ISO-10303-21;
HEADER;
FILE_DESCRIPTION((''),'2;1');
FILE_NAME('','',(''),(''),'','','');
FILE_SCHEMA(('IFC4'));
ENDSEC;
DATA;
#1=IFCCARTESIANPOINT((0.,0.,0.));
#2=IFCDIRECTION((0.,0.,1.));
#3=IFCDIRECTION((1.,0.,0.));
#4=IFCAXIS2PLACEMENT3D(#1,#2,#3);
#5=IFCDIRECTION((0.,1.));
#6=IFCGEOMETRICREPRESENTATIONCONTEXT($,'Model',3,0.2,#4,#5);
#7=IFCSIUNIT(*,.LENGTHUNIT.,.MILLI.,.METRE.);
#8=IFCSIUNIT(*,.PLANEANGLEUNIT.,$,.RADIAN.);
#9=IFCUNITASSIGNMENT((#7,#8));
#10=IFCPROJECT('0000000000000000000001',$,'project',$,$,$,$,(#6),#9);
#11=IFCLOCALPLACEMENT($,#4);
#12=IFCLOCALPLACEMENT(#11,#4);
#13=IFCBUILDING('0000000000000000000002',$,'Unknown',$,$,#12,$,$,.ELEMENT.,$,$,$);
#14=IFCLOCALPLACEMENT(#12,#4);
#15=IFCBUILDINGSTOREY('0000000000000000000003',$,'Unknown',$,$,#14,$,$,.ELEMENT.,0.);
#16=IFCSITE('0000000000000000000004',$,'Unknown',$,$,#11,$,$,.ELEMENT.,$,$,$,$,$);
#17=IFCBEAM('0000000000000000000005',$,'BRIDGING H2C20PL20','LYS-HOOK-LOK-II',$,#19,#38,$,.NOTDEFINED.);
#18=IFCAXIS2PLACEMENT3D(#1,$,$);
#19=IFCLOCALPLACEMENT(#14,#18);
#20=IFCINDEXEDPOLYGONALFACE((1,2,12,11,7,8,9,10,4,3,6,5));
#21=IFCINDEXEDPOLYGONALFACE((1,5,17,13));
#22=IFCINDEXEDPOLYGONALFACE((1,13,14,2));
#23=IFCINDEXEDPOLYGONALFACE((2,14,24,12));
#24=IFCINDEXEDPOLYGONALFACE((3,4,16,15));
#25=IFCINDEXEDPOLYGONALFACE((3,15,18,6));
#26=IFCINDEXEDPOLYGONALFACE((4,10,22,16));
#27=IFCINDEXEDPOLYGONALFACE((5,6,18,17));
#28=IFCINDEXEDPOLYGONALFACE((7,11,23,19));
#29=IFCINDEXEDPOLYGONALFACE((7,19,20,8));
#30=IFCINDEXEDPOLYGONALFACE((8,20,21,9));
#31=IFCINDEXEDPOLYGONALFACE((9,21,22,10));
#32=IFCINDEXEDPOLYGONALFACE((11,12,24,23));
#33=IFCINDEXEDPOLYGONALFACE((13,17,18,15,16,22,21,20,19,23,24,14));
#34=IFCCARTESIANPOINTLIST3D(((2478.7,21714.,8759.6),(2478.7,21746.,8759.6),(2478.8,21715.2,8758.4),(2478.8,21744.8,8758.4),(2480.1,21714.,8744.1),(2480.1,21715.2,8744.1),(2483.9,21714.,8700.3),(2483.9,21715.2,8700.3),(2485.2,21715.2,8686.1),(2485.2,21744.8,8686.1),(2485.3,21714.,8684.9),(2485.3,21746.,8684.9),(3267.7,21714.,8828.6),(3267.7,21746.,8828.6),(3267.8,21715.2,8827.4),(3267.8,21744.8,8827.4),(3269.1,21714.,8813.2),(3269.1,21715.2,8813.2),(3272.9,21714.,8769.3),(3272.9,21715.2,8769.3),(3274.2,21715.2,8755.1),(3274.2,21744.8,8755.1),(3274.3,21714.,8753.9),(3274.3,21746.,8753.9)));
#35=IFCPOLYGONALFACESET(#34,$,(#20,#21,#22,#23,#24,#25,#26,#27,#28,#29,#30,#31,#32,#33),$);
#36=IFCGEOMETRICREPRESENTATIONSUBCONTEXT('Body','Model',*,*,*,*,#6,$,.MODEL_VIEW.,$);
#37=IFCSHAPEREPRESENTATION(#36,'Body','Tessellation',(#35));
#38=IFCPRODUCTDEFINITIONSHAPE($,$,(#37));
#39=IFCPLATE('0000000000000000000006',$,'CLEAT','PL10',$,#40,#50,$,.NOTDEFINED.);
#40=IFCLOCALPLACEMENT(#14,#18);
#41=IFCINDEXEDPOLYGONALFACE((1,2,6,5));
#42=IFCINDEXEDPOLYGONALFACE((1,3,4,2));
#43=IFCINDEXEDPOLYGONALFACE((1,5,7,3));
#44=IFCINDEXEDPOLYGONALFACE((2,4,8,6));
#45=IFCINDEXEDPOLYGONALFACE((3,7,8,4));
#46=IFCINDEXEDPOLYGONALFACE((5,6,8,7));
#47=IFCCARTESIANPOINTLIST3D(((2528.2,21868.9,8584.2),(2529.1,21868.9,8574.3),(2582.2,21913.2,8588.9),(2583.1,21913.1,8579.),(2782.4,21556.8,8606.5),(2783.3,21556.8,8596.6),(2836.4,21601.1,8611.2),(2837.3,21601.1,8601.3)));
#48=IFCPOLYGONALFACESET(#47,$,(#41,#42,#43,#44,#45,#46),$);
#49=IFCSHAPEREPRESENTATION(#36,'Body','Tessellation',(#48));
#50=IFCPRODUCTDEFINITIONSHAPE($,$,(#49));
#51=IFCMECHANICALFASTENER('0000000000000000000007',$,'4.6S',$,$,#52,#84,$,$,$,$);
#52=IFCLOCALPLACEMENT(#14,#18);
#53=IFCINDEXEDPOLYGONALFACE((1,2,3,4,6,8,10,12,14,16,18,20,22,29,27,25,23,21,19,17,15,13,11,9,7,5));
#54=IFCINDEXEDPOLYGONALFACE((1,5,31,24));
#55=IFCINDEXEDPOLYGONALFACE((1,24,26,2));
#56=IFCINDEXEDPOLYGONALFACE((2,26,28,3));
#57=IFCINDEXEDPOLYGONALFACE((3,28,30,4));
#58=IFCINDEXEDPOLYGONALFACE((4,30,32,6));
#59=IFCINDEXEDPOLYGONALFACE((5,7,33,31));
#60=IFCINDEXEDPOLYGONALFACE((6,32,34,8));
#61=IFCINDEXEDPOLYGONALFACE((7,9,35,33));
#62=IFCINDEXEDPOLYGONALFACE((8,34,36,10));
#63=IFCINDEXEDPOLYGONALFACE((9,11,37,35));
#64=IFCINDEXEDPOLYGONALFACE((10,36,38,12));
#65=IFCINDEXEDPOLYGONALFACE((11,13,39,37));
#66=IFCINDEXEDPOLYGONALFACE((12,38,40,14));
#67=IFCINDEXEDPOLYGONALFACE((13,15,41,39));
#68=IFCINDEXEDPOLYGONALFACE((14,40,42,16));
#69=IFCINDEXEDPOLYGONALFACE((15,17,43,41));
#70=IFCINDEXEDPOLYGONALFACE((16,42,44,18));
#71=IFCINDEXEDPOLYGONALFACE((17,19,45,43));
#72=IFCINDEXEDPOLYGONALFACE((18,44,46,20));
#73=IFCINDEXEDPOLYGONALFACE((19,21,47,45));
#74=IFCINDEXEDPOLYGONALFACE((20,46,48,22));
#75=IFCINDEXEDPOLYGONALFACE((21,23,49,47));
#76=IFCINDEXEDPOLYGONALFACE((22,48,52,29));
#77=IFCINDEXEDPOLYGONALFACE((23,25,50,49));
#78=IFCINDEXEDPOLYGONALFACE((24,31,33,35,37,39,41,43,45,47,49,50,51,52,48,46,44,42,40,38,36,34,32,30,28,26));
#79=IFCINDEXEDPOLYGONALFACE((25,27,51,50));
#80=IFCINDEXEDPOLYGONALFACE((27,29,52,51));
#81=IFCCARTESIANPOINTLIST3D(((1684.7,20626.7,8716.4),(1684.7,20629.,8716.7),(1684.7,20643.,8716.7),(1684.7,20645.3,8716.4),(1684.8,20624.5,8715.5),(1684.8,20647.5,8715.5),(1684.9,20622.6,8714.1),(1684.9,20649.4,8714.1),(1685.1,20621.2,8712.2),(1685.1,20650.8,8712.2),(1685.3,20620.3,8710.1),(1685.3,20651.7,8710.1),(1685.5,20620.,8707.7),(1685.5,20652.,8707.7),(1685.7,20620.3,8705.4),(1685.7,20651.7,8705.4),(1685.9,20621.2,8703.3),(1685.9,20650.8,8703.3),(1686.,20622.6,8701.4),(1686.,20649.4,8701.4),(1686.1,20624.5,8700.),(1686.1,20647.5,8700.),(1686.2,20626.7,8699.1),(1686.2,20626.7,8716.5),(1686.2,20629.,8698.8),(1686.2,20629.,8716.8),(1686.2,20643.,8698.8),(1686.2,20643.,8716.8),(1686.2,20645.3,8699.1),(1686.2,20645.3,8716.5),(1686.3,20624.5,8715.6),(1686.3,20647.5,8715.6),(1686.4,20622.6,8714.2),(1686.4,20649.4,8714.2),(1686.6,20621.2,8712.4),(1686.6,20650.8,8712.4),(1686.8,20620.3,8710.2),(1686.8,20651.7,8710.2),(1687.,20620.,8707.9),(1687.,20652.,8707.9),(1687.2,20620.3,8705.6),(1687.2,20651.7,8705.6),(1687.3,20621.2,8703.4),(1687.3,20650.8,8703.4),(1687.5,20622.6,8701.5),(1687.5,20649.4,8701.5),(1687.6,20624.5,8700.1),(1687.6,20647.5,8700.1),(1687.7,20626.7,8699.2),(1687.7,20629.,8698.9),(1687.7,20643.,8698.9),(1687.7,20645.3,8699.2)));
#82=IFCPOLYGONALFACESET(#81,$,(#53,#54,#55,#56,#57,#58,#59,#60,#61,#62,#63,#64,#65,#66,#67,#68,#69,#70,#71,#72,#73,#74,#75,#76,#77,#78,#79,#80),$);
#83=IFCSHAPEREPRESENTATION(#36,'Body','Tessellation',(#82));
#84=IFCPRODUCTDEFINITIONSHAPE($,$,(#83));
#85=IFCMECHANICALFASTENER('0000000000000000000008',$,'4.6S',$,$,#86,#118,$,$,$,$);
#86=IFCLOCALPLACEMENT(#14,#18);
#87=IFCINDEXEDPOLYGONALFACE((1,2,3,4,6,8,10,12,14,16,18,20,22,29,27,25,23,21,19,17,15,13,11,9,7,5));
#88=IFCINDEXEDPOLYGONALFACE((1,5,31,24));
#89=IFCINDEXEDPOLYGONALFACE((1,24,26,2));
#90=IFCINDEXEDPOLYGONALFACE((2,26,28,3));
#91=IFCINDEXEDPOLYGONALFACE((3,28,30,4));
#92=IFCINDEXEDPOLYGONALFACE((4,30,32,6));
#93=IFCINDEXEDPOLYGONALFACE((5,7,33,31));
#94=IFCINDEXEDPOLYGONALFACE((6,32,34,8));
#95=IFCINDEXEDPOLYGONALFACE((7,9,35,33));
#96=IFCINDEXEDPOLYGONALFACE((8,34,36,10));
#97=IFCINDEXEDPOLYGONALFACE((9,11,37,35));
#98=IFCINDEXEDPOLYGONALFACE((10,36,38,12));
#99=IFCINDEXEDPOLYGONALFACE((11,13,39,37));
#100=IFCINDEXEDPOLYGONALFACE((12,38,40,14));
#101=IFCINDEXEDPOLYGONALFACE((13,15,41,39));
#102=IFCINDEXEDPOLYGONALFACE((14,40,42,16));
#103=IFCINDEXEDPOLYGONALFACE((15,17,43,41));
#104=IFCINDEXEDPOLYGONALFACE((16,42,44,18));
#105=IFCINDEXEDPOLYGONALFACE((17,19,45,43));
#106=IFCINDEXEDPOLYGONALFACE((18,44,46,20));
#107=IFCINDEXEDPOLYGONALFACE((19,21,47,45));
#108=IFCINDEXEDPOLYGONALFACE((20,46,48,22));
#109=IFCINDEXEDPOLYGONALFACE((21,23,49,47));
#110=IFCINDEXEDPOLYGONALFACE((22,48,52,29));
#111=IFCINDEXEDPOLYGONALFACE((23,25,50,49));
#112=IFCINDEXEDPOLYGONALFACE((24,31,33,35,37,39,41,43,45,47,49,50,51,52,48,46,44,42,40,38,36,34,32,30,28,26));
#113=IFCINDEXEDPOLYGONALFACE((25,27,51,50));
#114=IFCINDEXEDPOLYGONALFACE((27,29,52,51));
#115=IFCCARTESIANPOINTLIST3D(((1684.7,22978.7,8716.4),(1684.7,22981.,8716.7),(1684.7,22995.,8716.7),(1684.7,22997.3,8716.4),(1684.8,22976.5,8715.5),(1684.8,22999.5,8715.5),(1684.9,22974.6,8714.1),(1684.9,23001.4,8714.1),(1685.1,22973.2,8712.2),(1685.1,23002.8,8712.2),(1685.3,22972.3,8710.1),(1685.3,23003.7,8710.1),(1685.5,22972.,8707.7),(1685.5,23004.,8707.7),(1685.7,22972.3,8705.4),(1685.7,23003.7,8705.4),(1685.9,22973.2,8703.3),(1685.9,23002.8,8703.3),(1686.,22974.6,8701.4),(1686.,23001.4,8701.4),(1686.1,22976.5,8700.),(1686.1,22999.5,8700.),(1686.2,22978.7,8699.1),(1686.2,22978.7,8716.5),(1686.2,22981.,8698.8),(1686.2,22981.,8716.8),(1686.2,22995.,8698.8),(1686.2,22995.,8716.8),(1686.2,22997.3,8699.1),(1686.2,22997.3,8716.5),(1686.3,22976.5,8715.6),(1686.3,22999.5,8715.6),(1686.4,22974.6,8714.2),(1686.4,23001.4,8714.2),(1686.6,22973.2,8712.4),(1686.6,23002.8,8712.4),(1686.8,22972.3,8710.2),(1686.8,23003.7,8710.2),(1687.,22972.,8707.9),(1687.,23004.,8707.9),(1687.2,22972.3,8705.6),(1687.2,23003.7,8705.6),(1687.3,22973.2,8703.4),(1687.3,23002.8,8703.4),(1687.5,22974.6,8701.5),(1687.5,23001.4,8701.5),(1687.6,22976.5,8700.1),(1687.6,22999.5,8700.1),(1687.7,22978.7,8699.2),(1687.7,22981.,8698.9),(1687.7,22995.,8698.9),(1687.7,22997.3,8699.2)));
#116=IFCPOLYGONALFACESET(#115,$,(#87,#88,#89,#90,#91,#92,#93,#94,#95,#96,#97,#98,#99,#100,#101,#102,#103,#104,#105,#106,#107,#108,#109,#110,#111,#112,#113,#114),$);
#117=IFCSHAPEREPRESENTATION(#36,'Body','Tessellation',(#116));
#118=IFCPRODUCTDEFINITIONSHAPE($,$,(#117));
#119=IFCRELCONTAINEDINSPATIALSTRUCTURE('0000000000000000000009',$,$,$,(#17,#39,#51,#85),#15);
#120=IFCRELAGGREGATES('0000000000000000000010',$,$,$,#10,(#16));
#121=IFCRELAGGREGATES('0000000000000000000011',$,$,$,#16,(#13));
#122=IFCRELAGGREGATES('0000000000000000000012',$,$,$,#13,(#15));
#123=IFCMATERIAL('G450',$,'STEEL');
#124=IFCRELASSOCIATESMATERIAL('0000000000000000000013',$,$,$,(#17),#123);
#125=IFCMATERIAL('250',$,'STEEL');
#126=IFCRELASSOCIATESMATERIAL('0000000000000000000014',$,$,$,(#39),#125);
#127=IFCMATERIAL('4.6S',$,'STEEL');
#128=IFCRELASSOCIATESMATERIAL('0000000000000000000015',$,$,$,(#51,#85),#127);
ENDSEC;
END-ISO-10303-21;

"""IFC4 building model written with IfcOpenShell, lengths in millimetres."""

from ifc_helpers import new_model, si_unit, direction, frame, origin_with_axes, place, context, subcontext, project, spatial, line, arc, indexed_curve, outline, extrude, source, transform, mapped, material, element, save


model = new_model("IFC4")

# Units and contexts
model_context = context("Model", 3, precision=0.2, world=origin_with_axes(), true_north=direction((0.0, 1.0)))
body_context = subcontext(model_context, "Body", "Model", "MODEL_VIEW")
ifc_project = project(units=[si_unit("LENGTHUNIT", "METRE", prefix="MILLI"), si_unit("PLANEANGLEUNIT", "RADIAN")], contexts=[model_context])

# Site, building, storey
site_placement = place(None, origin_with_axes())
site = spatial("IfcSite", under=ifc_project, at=site_placement, Name="Unknown", CompositionType="ELEMENT")
building_placement = place(site_placement, origin_with_axes())
building = spatial("IfcBuilding", under=site, at=building_placement, Name="Unknown", CompositionType="ELEMENT")
storey_placement = place(building_placement, origin_with_axes())
storey = spatial("IfcBuildingStorey", under=building, at=storey_placement, Name="Unknown", CompositionType="ELEMENT", Elevation=0.0)

# Beam
ifc_material_1 = material(Name="250", Category="STEEL")
ifc_material_2 = material(Name="G450", Category="STEEL")
beam_1_placement = place(storey_placement, frame((2482.0, 21730.0, 8722.2), z_axis=(0.0, -1.0, 0.0), x_axis=(0.996195, 0.0, 0.087156)))
element("IfcBeam", 1, at=beam_1_placement, inside=storey, material=ifc_material_2, Name="BRIDGING H2C20PL20", Description="LYS-HOOK-LOK-II", PredefinedType="NOTDEFINED", context=body_context, shape_type="SolidModel", body=[
    extrude(outline(indexed_curve([(16.0, -37.5), (16.0, -22.0), (14.8, -22.0), (14.8, -36.3), (-14.8, -36.3), (-14.8, 36.3), (14.8, 36.3), (14.8, 22.0), (16.0, 22.0), (16.0, 37.5), (-16.0, 37.5), (-16.0, -37.5)], segments=[line(1, 2, 3, 4, 5, 6, 7, 8, 9, 10, 11, 12, 1)])), frame((0.0, 0.0, 0.0), z_axis=(-1.0, 0.0, 0.0), x_axis=(0.0, 0.0, 1.0)), (0.0, 0.0, -1.0), 792.0),
])

# Plate
plate_placement = place(storey_placement, frame((2528.6, 21868.9, 8579.2), z_axis=(-0.086969, 0.00032, 0.996211), x_axis=(0.630602, -0.774134, 0.055301)))
element("IfcPlate", 2, at=plate_placement, inside=storey, material=ifc_material_1, Name="CLEAT", Description="PL10", PredefinedType="NOTDEFINED", context=body_context, shape_type="SolidModel", body=[
    extrude(outline(indexed_curve([(0.0, 0.0), (403.1, 0.0), (403.2, 70.0), (0.0, 70.0)], segments=[line(1, 2, 3, 4, 1)])), frame((0.0, 0.0, 5.0), z_axis=(0.0, 0.0, 1.0), x_axis=(1.0, 0.0, 0.0)), (0.0, 0.0, -1.0), 10.0),
])

# Mechanical fasteners
ifc_material_3 = material(Name="4.6S", Category="STEEL")
shared_shape_1 = source(origin_with_axes(), body_context, "Body", "SweptSolid", [
    extrude(outline(indexed_curve([(-7.0, 9.0), (7.0, 9.0), (7.0, 9.0), (13.4, 6.4), (16.0, 0.0), (13.4, -6.4), (7.0, -9.0), (-7.0, -9.0), (-7.8, -9.0), (-16.0, 0.0), (-13.4, 6.4)], segments=[line(1, 2, 3), arc(3, 4, 5), arc(5, 6, 7), line(7, 8), arc(8, 9, 10), arc(10, 11, 1)])), frame((0.0, 0.0, 0.8), z_axis=(0.0, 0.0, -1.0), x_axis=(0.0, 1.0, 0.0)), (0.0, 0.0, 1.0), 1.5),
])
for number, where, z_axis, x_axis, name in (
    (3, (1686.2, 20636.0, 8707.8), (0.996195, 0.0, 0.087156), (0.087156, 0.0, -0.996195), "4.6S"),
    (4, (1686.2, 22988.0, 8707.8), (0.996195, 0.0, 0.087156), (0.087156, 0.0, -0.996195), "4.6S"),
):
    element("IfcMechanicalFastener", number, at=place(storey_placement, frame(where, z_axis=z_axis, x_axis=x_axis)), inside=storey, material=ifc_material_3, Name=name, context=body_context, shape_type="MappedRepresentation", body=[
        mapped(shared_shape_1, transform((0.0, 0.0, 0.0))),
    ])

save(model, "model.ifc")
